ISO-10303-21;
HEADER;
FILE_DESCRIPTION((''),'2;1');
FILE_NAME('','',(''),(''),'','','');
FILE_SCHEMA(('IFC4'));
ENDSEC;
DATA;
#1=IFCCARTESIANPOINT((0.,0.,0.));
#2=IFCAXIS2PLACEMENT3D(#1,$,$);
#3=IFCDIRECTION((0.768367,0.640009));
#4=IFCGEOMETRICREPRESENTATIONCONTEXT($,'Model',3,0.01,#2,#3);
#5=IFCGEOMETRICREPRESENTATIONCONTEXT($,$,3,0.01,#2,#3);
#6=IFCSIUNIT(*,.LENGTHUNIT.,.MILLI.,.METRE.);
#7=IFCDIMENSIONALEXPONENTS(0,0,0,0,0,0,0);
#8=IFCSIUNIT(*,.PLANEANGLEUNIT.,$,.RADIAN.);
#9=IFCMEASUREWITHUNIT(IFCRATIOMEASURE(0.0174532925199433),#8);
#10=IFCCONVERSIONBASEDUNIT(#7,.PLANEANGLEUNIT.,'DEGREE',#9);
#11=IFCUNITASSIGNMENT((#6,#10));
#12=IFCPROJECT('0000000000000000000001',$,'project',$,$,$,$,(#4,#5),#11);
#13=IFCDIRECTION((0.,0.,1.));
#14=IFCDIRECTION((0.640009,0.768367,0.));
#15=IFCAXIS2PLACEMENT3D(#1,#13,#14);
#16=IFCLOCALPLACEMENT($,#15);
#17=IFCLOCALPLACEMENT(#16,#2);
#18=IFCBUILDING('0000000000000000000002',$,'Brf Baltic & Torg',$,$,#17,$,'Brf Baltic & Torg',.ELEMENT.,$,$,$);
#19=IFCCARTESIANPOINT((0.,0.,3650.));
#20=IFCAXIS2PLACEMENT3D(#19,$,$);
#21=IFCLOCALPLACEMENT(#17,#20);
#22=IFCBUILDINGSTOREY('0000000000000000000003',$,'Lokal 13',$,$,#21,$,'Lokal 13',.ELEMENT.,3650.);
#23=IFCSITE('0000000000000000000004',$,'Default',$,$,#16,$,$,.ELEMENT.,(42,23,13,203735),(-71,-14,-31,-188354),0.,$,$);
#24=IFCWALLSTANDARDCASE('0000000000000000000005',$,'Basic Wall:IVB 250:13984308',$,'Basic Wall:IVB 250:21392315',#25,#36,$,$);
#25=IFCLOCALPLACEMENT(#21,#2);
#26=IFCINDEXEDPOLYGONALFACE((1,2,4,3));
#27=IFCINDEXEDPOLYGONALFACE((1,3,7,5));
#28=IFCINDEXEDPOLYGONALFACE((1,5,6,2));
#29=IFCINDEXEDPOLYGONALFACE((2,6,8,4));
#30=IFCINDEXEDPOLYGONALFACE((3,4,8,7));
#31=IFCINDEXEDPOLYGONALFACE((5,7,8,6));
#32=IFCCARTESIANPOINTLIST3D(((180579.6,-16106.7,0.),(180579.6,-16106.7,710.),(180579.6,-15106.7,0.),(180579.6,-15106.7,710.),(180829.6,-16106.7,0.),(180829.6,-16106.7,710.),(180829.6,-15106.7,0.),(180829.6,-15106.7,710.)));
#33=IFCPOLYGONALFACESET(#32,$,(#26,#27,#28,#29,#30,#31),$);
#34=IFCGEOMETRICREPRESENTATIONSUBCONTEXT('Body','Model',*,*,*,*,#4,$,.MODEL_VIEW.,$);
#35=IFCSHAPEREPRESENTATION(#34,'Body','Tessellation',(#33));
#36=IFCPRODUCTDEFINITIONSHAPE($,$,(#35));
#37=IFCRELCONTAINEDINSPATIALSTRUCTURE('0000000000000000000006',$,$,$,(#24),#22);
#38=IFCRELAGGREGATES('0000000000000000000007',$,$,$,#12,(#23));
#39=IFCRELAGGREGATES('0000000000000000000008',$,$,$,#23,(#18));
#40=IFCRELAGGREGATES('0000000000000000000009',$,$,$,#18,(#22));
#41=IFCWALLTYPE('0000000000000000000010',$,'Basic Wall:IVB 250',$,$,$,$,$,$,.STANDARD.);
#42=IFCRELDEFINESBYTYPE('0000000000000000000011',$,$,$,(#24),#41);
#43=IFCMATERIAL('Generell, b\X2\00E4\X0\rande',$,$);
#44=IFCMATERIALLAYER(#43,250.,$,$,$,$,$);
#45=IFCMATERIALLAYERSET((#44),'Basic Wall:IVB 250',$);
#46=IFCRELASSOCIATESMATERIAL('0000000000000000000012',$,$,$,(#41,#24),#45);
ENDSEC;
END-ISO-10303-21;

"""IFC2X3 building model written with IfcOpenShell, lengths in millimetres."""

from ifc_helpers import new_model, entity, si_unit, converted_unit, direction, frame, frame_2d, origin, place, context, subcontext, project, spatial, rectangle, extrude, clip, halfspace, material, layer, layer_set, layer_usage, type_object, element, save


model = new_model("IFC2X3")

# Units and contexts
model_context = context("Model", 3, precision=0.01, world=origin(), true_north=direction((0.768367, 0.640009)))
context_of_model = context(None, 3, precision=0.01, world=origin(), true_north=direction((0.768367, 0.640009)))
body_context = subcontext(model_context, "Body", "Model", "MODEL_VIEW")
ifc_project = project(units=[si_unit("LENGTHUNIT", "METRE", prefix="MILLI"), converted_unit("PLANEANGLEUNIT", "DEGREE", entity("IfcRatioMeasure", 0.0174532925199433), si_unit("PLANEANGLEUNIT", "RADIAN"), dimensions=[0, 0, 0, 0, 0, 0, 0])], contexts=[model_context, context_of_model])

# Site, building, storey
site_placement = place(None, frame((0.0, 0.0, 0.0), z_axis=(0.0, 0.0, 1.0), x_axis=(0.640009, 0.768367, 0.0)))
site = spatial("IfcSite", under=ifc_project, at=site_placement, Name="Default", CompositionType="ELEMENT", RefLatitude=(42, 23, 13, 203735), RefLongitude=(-71, -14, -31, -188354), RefElevation=0.0)
building_placement = place(site_placement, origin())
building = spatial("IfcBuilding", under=site, at=building_placement, Name="Brf Baltic & Torg", LongName="Brf Baltic & Torg", CompositionType="ELEMENT")
storey_placement = place(building_placement, frame((0.0, 0.0, 3650.0)))
storey = spatial("IfcBuildingStorey", under=building, at=storey_placement, Name="Lokal 13", LongName="Lokal 13", CompositionType="ELEMENT", Elevation=3650.0)

# Shared definitions
ifc_material = material(Name="Generell, bärande")

# Wall
ifc_layer_1 = layer(ifc_material, 250.0)
ifc_layer_set_1 = layer_set([ifc_layer_1], Name="Basic Wall:IVB 250")
ifc_layer_usage_1 = layer_usage(ifc_layer_set_1, "AXIS2", "NEGATIVE", 125.0)
wall_type_1 = type_object("IfcWallType", Name="Basic Wall:IVB 250", PredefinedType="STANDARD", material=ifc_layer_set_1)
wall_1_placement = place(storey_placement, frame((180704.6, -15106.7, 0.0), z_axis=(0.0, 0.0, 1.0), x_axis=(0.0, -1.0, 0.0)))
element("IfcWallStandardCase", 1, at=wall_1_placement, inside=storey, type_object=wall_type_1, material=ifc_layer_usage_1, Name="Basic Wall:IVB 250:13984308", ObjectType="Basic Wall:IVB 250:21392315", context=body_context, shape_type="Clipping", body=[
    clip(extrude(rectangle(XDim=1000.0, YDim=250.0, at=frame_2d((500.0, 0.0), x_axis=(-1.0, 0.0))), origin(), (0.0, 0.0, 1.0), 710.0), halfspace(frame((0.0, 0.0, -2000.0)), True)),
])

save(model, "model.ifc")
